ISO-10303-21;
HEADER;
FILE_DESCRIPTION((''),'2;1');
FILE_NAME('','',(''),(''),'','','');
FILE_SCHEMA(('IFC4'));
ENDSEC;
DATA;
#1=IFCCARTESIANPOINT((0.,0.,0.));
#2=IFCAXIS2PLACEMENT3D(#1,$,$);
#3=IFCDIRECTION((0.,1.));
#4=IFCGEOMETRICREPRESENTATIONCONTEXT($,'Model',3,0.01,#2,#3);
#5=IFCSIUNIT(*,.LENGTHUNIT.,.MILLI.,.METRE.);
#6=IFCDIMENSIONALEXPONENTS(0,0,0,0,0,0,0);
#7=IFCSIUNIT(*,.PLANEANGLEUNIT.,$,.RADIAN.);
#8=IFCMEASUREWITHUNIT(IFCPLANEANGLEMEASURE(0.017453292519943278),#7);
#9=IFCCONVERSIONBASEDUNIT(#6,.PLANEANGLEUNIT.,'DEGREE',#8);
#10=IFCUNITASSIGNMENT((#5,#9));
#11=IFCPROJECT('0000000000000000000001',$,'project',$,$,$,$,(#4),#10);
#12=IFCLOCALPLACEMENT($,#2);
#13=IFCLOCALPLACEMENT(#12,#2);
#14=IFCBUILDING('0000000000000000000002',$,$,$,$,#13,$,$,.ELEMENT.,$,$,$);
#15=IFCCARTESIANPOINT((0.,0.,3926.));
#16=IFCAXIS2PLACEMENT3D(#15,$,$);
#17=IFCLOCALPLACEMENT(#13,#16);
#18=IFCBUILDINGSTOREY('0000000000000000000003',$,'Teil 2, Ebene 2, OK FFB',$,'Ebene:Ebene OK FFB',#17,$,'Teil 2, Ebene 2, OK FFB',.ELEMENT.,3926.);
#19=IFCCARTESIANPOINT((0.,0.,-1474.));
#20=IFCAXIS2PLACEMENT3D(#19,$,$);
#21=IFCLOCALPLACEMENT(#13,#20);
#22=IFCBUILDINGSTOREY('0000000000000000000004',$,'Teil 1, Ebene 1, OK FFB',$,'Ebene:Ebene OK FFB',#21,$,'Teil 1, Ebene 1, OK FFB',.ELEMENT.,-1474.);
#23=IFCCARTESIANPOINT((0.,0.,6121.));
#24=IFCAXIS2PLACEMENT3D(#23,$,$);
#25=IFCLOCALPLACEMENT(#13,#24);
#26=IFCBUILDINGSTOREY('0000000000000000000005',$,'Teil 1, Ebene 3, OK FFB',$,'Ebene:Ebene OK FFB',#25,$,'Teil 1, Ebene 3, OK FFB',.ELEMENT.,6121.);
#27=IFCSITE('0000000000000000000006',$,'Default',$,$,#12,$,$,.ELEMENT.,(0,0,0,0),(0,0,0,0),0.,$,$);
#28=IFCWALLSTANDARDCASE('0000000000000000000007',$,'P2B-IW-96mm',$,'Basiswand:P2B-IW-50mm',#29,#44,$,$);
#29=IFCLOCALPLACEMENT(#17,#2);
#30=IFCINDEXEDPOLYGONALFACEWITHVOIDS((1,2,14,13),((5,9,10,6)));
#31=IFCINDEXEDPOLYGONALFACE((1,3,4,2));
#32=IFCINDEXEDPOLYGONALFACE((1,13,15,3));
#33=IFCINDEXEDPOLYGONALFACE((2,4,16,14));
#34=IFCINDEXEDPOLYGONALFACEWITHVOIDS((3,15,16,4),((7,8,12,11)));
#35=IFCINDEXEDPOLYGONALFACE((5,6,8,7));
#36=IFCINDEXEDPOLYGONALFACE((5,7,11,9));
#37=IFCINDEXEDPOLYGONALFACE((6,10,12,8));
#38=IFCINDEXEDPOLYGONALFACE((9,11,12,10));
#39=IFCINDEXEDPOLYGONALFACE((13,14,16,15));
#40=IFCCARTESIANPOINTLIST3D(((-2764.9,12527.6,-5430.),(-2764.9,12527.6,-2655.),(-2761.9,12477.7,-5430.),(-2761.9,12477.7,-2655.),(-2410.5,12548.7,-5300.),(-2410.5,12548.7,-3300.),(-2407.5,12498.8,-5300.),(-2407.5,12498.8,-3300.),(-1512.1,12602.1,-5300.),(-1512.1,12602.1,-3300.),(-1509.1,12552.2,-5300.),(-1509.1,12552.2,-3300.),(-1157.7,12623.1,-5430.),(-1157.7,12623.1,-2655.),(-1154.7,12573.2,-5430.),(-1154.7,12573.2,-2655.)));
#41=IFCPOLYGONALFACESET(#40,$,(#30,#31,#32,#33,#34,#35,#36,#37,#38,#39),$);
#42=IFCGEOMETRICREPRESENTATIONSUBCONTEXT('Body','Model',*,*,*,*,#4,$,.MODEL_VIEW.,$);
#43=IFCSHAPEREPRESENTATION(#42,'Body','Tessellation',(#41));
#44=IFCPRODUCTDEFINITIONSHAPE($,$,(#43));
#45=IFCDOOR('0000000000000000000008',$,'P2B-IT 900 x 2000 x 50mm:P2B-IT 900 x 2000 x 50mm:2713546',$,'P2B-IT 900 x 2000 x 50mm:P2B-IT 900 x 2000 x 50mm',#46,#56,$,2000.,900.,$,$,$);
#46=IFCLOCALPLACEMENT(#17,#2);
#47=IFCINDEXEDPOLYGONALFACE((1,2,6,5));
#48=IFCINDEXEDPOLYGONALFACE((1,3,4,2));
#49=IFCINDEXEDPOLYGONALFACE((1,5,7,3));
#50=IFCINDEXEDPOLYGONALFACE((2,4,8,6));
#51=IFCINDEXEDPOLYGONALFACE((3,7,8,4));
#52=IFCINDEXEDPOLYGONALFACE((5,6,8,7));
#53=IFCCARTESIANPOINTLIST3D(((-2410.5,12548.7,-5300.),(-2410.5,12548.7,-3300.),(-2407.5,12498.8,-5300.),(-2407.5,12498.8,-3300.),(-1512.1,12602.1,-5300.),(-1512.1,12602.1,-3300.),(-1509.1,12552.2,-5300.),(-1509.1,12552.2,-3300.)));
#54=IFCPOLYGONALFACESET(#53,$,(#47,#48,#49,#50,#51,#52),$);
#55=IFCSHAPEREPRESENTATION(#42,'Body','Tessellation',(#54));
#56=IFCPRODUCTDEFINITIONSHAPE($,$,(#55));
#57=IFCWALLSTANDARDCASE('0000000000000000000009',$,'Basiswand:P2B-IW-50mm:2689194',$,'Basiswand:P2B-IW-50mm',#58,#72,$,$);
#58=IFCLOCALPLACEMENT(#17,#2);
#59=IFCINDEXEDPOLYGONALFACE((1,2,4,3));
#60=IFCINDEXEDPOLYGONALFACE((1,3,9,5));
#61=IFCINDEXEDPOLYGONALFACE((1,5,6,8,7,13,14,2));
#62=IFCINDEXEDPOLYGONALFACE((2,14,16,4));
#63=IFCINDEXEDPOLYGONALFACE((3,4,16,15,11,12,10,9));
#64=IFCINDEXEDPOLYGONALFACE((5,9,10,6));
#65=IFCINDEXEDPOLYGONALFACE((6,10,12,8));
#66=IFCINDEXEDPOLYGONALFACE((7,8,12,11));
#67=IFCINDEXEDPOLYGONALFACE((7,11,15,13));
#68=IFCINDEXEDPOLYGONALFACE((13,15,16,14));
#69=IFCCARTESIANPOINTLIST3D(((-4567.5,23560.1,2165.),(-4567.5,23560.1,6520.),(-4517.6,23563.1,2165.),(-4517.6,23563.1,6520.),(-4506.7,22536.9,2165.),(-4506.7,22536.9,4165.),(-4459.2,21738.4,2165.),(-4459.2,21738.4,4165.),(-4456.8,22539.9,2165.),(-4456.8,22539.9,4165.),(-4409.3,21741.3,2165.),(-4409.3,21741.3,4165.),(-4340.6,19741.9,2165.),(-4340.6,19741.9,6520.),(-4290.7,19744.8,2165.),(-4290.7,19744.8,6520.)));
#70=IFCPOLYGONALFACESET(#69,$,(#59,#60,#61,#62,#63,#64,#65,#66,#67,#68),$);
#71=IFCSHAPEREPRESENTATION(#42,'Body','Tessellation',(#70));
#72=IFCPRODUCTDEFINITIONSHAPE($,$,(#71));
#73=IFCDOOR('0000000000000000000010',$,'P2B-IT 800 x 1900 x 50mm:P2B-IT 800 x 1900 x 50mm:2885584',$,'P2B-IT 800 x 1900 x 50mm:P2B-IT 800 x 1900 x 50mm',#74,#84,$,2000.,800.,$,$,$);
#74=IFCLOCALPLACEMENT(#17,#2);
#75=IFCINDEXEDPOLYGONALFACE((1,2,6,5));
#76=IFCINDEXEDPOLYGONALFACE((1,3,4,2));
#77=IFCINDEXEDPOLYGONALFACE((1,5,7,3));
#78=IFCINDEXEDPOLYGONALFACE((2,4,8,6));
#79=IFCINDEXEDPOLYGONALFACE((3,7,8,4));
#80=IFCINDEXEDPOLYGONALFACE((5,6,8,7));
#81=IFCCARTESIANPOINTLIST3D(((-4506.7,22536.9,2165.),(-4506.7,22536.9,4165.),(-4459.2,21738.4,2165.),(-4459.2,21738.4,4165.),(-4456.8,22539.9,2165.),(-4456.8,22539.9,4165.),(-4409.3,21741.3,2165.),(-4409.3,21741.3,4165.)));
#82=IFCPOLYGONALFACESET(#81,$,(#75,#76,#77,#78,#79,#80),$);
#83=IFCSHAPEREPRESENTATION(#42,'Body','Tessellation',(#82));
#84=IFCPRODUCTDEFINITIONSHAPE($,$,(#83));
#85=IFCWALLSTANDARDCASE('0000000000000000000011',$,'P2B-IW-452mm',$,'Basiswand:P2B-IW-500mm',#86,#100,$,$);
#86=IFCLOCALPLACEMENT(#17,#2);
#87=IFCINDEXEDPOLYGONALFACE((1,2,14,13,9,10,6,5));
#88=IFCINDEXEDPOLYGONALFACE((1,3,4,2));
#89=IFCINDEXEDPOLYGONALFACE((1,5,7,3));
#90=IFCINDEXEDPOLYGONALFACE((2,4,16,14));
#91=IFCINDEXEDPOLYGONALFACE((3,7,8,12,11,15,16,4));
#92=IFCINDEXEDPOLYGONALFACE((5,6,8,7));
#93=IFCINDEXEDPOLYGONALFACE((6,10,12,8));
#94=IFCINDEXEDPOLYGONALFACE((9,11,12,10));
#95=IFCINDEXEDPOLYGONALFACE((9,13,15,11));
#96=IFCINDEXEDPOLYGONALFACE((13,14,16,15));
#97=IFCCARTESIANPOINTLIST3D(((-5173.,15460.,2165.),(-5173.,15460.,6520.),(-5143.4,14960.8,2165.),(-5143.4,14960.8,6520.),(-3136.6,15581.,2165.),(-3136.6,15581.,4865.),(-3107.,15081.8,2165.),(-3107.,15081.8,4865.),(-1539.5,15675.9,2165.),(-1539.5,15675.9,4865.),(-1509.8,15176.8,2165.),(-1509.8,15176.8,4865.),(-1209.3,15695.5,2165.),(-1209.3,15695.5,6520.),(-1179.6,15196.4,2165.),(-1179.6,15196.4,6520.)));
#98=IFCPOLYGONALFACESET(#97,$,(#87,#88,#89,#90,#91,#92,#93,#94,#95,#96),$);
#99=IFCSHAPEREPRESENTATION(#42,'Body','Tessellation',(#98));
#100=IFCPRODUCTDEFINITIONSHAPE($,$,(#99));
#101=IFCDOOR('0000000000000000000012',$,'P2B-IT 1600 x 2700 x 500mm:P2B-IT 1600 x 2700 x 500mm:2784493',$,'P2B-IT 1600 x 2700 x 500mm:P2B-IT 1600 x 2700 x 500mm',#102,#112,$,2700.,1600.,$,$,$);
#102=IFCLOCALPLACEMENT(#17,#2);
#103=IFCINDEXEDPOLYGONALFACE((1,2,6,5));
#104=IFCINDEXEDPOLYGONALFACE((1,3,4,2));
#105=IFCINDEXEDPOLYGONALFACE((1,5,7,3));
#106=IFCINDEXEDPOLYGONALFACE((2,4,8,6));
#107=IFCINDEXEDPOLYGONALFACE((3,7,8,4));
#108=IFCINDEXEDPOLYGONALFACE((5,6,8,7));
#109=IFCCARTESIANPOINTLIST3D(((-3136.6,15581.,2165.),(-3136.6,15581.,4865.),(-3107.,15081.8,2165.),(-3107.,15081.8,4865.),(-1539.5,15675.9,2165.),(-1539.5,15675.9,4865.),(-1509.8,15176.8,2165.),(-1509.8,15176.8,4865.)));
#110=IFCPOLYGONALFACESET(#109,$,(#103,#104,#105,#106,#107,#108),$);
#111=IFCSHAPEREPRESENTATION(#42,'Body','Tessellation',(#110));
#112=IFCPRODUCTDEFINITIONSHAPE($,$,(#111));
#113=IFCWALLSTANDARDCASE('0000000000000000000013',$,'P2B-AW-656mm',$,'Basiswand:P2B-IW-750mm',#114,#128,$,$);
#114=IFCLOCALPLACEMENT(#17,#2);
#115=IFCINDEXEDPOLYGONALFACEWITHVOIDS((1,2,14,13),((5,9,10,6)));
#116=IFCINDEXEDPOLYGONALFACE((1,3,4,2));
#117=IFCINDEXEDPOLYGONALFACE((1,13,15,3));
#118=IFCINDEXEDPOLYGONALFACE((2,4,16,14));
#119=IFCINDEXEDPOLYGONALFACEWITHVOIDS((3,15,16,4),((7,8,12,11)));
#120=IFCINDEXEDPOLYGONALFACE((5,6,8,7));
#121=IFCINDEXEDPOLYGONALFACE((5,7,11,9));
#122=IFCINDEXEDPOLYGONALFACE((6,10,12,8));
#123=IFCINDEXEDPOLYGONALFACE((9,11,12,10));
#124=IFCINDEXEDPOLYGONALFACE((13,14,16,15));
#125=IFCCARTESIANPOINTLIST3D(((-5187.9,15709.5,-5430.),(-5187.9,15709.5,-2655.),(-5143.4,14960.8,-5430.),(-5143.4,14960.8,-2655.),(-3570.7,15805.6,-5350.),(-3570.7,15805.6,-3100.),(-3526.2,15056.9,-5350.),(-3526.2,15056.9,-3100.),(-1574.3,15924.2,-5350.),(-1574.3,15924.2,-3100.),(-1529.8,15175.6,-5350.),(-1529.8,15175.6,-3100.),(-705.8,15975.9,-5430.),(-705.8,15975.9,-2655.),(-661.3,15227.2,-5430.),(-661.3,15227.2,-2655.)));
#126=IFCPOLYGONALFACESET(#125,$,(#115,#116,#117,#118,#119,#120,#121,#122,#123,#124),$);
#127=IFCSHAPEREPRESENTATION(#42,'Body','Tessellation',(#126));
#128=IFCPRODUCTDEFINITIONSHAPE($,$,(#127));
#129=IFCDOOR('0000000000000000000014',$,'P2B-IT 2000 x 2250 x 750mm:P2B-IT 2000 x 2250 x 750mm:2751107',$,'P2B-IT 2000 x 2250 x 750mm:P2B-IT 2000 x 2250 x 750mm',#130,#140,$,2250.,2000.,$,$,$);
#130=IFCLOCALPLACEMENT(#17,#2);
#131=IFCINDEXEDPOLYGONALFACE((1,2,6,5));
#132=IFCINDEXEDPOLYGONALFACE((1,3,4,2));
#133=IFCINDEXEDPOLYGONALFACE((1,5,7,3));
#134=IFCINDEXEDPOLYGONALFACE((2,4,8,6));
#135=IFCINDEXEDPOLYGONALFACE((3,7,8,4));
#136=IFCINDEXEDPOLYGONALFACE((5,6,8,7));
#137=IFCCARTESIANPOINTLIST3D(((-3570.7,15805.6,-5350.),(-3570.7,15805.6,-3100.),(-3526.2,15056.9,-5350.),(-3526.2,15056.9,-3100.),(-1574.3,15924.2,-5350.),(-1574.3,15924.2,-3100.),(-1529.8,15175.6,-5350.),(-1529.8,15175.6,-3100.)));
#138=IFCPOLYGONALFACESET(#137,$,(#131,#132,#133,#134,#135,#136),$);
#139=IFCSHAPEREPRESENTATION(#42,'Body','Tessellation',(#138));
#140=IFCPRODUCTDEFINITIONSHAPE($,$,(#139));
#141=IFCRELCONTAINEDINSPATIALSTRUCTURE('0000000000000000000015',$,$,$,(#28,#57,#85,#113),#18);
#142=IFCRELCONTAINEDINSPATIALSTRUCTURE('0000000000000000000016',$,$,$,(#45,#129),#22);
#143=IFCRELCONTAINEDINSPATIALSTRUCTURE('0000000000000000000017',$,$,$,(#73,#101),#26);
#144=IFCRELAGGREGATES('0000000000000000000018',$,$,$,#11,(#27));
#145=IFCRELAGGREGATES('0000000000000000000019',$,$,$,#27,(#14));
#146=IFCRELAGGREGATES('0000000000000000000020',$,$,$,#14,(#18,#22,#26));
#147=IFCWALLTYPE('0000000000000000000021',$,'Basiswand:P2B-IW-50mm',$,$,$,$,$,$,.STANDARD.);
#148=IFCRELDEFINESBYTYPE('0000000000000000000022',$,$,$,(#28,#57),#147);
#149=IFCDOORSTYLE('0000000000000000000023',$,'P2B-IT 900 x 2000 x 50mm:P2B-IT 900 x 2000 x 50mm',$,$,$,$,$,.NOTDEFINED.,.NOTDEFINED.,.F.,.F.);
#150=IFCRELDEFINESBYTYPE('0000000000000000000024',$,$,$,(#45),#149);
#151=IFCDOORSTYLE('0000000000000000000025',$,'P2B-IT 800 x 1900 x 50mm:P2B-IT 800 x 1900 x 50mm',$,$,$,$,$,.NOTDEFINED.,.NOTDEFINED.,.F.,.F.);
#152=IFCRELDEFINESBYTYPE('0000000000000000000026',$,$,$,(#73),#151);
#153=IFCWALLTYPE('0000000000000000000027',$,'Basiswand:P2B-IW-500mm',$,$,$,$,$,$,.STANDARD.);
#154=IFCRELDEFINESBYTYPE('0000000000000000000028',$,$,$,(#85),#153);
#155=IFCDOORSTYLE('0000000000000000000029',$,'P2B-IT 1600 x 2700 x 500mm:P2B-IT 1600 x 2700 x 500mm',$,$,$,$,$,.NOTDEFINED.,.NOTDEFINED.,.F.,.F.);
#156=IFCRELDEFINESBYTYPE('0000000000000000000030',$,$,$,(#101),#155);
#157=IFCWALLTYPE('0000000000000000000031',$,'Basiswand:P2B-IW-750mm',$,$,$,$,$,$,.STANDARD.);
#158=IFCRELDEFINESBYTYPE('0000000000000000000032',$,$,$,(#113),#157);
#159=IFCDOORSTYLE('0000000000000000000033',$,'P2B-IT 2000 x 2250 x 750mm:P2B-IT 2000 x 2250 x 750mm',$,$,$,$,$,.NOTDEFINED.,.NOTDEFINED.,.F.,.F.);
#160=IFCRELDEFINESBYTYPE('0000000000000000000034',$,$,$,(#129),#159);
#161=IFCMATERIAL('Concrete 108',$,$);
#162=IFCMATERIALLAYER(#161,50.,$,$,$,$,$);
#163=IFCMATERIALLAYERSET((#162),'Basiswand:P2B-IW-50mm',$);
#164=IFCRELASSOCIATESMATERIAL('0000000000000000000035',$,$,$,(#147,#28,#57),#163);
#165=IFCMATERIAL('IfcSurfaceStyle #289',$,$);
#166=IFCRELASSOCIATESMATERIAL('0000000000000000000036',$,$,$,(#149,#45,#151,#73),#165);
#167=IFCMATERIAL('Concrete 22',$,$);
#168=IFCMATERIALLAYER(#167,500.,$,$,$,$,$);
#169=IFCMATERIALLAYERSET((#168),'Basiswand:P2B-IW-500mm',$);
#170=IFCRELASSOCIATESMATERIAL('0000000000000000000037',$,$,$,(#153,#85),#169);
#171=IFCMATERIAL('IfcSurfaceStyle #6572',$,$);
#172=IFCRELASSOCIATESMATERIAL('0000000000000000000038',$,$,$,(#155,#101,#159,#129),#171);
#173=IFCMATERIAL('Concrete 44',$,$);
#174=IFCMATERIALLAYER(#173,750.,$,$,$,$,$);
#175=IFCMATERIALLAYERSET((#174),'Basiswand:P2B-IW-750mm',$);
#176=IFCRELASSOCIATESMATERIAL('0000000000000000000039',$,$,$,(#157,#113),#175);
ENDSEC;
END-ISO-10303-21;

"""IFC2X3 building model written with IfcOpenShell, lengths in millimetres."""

from ifc_helpers import new_model, entity, si_unit, converted_unit, direction, frame, frame_2d, origin, origin_2d_with_axis, place, context, subcontext, project, spatial, rectangle, extrude, source, transform, mapped, material, layer, layer_set, layer_usage, type_object, type_shapes, element, fill, save


model = new_model("IFC2X3")

# Units and contexts
model_context = context("Model", 3, precision=0.01, world=origin(), true_north=direction((0.0, 1.0)))
body_context = subcontext(model_context, "Body", "Model", "MODEL_VIEW")
ifc_project = project(units=[si_unit("LENGTHUNIT", "METRE", prefix="MILLI"), converted_unit("PLANEANGLEUNIT", "DEGREE", entity("IfcPlaneAngleMeasure", 0.017453292519943278), si_unit("PLANEANGLEUNIT", "RADIAN"), dimensions=[0, 0, 0, 0, 0, 0, 0])], contexts=[model_context])

# Site, building, storey
site_placement = place(None, origin())
site = spatial("IfcSite", under=ifc_project, at=site_placement, Name="Default", CompositionType="ELEMENT", RefLatitude=(0, 0, 0, 0), RefLongitude=(0, 0, 0, 0), RefElevation=0.0)
building_placement = place(site_placement, origin())
building = spatial("IfcBuilding", under=site, at=building_placement, CompositionType="ELEMENT")
storey_1_placement = place(building_placement, frame((0.0, 0.0, 3926.0)))
storey_1 = spatial("IfcBuildingStorey", under=building, at=storey_1_placement, Name="Teil 2, Ebene 2, OK FFB", ObjectType="Ebene:Ebene OK FFB", LongName="Teil 2, Ebene 2, OK FFB", CompositionType="ELEMENT", Elevation=3926.0)

# Shared definitions
storey_2_placement = place(building_placement, frame((0.0, 0.0, -1474.0)))
storey_2 = spatial("IfcBuildingStorey", under=building, at=storey_2_placement, Name="Teil 1, Ebene 1, OK FFB", ObjectType="Ebene:Ebene OK FFB", LongName="Teil 1, Ebene 1, OK FFB", CompositionType="ELEMENT", Elevation=-1474.0)

# Shared definitions
ifc_material_1 = material(Name="IfcSurfaceStyle #289")

# Shared definitions
ifc_material_2 = material(Name="Concrete 44")

# Shared definitions
storey_3_placement = place(building_placement, frame((0.0, 0.0, 6121.0)))
storey_3 = spatial("IfcBuildingStorey", under=building, at=storey_3_placement, Name="Teil 1, Ebene 3, OK FFB", ObjectType="Ebene:Ebene OK FFB", LongName="Teil 1, Ebene 3, OK FFB", CompositionType="ELEMENT", Elevation=6121.0)

# Walls, openings, doors
ifc_material_3 = material(Name="Concrete 108")
ifc_layer_1 = layer(ifc_material_3, 50.0)
ifc_layer_set_1 = layer_set([ifc_layer_1], Name="Basiswand:P2B-IW-50mm")
ifc_layer_usage_1 = layer_usage(ifc_layer_set_1, "AXIS2", "NEGATIVE", 25.0)
wall_type_1 = type_object("IfcWallType", Name="Basiswand:P2B-IW-50mm", PredefinedType="STANDARD", material=ifc_layer_set_1)
wall_1_placement = place(storey_1_placement, frame((-1156.2, 12598.2, -5430.0), z_axis=(0.0, 0.0, 1.0), x_axis=(-0.998239, -0.059319, 0.0)))
wall_1 = element("IfcWallStandardCase", 1, at=wall_1_placement, inside=storey_1, type_object=wall_type_1, material=ifc_layer_usage_1, Name="P2B-IW-96mm", ObjectType="Basiswand:P2B-IW-50mm", context=body_context, shape_type="SweptSolid", body=[
    extrude(rectangle(XDim=1610.0, YDim=50.0, at=frame_2d((805.0, 0.0), x_axis=(-1.0, 0.0))), origin(), (0.0, 0.0, 1.0), 2775.0),
])
opening_1_placement = place(wall_1_placement, frame((-406.9, 12644.6, 30.0), z_axis=(0.0, 0.0, 1.0), x_axis=(-0.998239, 0.059319, 0.0)))
opening_1 = element("IfcOpeningElement", 2, at=opening_1_placement, cuts=wall_1, ObjectType="Opening", context=body_context, shape_type="SweptSolid", body=[
    extrude(rectangle(XDim=2000.0, YDim=900.0, at=frame_2d((0.0, 0.0), x_axis=(1.0, 0.0))), frame((-1961.3, 12575.4, 1100.0), z_axis=(0.059319, -0.998239, 0.0), x_axis=(0.0, 0.0, -1.0)), (0.0, 0.0, 1.0), 50.0),
])
door_style_1 = type_object("IfcDoorStyle", Name="P2B-IT 900 x 2000 x 50mm:P2B-IT 900 x 2000 x 50mm", ConstructionType="NOTDEFINED", OperationType="NOTDEFINED", ParameterTakesPrecedence=False, Sizeable=False, material=ifc_material_1)
shared_shape_1 = source(origin(), body_context, "Body", "SweptSolid", [
    extrude(rectangle(XDim=50.0, YDim=900.0, at=origin_2d_with_axis()), frame((450.0, 25.0, 0.0), z_axis=(0.0, 0.0, 1.0), x_axis=(0.0, 1.0, 0.0)), (0.0, 0.0, 1.0), 2000.0),
])
type_shapes(door_style_1, [shared_shape_1])
door_1_placement = place(opening_1_placement, frame((-2407.5, 12498.8, 100.0), z_axis=(0.0, 0.0, 1.0), x_axis=(0.998239, 0.059319, 0.0)))
door_1 = element("IfcDoor", 3, at=door_1_placement, inside=storey_2, type_object=door_style_1, material=ifc_material_1, Name="P2B-IT 900 x 2000 x 50mm:P2B-IT 900 x 2000 x 50mm:2713546", ObjectType="P2B-IT 900 x 2000 x 50mm:P2B-IT 900 x 2000 x 50mm", OverallHeight=2000.0, OverallWidth=900.0, context=body_context, shape_type="MappedRepresentation", body=[
    mapped(shared_shape_1, transform((0.0, 0.0, 0.0), scale=1.0)),
])
fill(opening_1, door_1)
ifc_layer_usage_2 = layer_usage(ifc_layer_set_1, "AXIS2", "NEGATIVE", 25.0)
wall_2_placement = place(storey_1_placement, frame((-4315.6, 19743.4, 2165.0), z_axis=(0.0, 0.0, 1.0), x_axis=(-0.059319, 0.998239, 0.0)))
wall_2 = element("IfcWallStandardCase", 4, at=wall_2_placement, inside=storey_1, type_object=wall_type_1, material=ifc_layer_usage_2, Name="Basiswand:P2B-IW-50mm:2689194", ObjectType="Basiswand:P2B-IW-50mm", context=body_context, shape_type="SweptSolid", body=[
    extrude(rectangle(XDim=3825.0, YDim=50.0, at=frame_2d((1912.5, 0.0), x_axis=(1.0, 0.0))), origin(), (0.0, 0.0, 1.0), 4355.0),
])
opening_2_placement = place(wall_2_placement, frame((-19964.6, -3136.9, 30.0), z_axis=(0.0, 0.0, 1.0), x_axis=(-0.059319, -0.998239, 0.0)))
opening_2 = element("IfcOpeningElement", 5, at=opening_2_placement, cuts=wall_2, ObjectType="Opening", context=body_context, shape_type="SweptSolid", body=[
    extrude(rectangle(XDim=2000.0, YDim=800.0, at=frame_2d((0.0, 0.0), x_axis=(1.0, 0.0))), frame((-4433.0, 22140.6, 970.0), z_axis=(-0.998239, -0.059319, 0.0), x_axis=(0.0, 0.0, -1.0)), (0.0, 0.0, 1.0), 50.0),
])
door_style_2 = type_object("IfcDoorStyle", Name="P2B-IT 800 x 1900 x 50mm:P2B-IT 800 x 1900 x 50mm", ConstructionType="NOTDEFINED", OperationType="NOTDEFINED", ParameterTakesPrecedence=False, Sizeable=False, material=ifc_material_1)
shared_shape_2 = source(origin(), body_context, "Body", "SweptSolid", [
    extrude(rectangle(XDim=50.0, YDim=800.0, at=origin_2d_with_axis()), frame((400.0, -25.0, 0.0), z_axis=(0.0, 0.0, 1.0), x_axis=(0.0, 1.0, 0.0)), (0.0, 0.0, 1.0), 2000.0),
])
type_shapes(door_style_2, [shared_shape_2])
door_2_placement = place(opening_2_placement, frame((-4459.2, 21738.4, -30.0), z_axis=(0.0, 0.0, 1.0), x_axis=(-0.059319, 0.998239, 0.0)))
door_2 = element("IfcDoor", 6, at=door_2_placement, inside=storey_3, type_object=door_style_2, material=ifc_material_1, Name="P2B-IT 800 x 1900 x 50mm:P2B-IT 800 x 1900 x 50mm:2885584", ObjectType="P2B-IT 800 x 1900 x 50mm:P2B-IT 800 x 1900 x 50mm", OverallHeight=2000.0, OverallWidth=800.0, context=body_context, shape_type="MappedRepresentation", body=[
    mapped(shared_shape_2, transform((0.0, 0.0, 0.0), scale=1.0)),
])
fill(opening_2, door_2)
ifc_material_4 = material(Name="Concrete 22")
ifc_layer_2 = layer(ifc_material_4, 500.0)
ifc_layer_set_2 = layer_set([ifc_layer_2], Name="Basiswand:P2B-IW-500mm")
ifc_layer_usage_3 = layer_usage(ifc_layer_set_2, "AXIS2", "NEGATIVE", 250.0)
wall_type_2 = type_object("IfcWallType", Name="Basiswand:P2B-IW-500mm", PredefinedType="STANDARD", material=ifc_layer_set_2)
wall_3_placement = place(storey_1_placement, frame((-1194.5, 15445.9, 2165.0), z_axis=(0.0, 0.0, 1.0), x_axis=(-0.998239, -0.059319, 0.0)))
wall_3 = element("IfcWallStandardCase", 7, at=wall_3_placement, inside=storey_1, type_object=wall_type_2, material=ifc_layer_usage_3, Name="P2B-IW-452mm", ObjectType="Basiswand:P2B-IW-500mm", context=body_context, shape_type="SweptSolid", body=[
    extrude(rectangle(XDim=3970.7, YDim=500.0, at=frame_2d((1985.4, 0.0), x_axis=(1.0, 0.0))), origin(), (0.0, 0.0, 1.0), 4355.0),
])
opening_3_placement = place(wall_3_placement, frame((-276.1, 15489.6, 30.0), z_axis=(0.0, 0.0, 1.0), x_axis=(-0.998239, 0.059319, 0.0)))
opening_3 = element("IfcOpeningElement", 8, at=opening_3_placement, cuts=wall_3, ObjectType="Opening", context=body_context, shape_type="SweptSolid", body=[
    extrude(rectangle(XDim=2700.0, YDim=1600.0, at=frame_2d((0.0, 0.0), x_axis=(1.0, 0.0))), frame((-2338.0, 15628.4, 1320.0), z_axis=(0.059319, -0.998239, 0.0), x_axis=(0.0, 0.0, -1.0)), (0.0, 0.0, 1.0), 500.0),
])
ifc_material_5 = material(Name="IfcSurfaceStyle #6572")
door_style_3 = type_object("IfcDoorStyle", Name="P2B-IT 1600 x 2700 x 500mm:P2B-IT 1600 x 2700 x 500mm", ConstructionType="NOTDEFINED", OperationType="NOTDEFINED", ParameterTakesPrecedence=False, Sizeable=False, material=ifc_material_5)
shared_shape_3 = source(origin(), body_context, "Body", "SweptSolid", [
    extrude(rectangle(XDim=500.0, YDim=1600.0, at=origin_2d_with_axis()), frame((800.0, 250.0, 0.0), z_axis=(0.0, 0.0, 1.0), x_axis=(0.0, 1.0, 0.0)), (0.0, 0.0, 1.0), 2700.0),
])
type_shapes(door_style_3, [shared_shape_3])
door_3_placement = place(opening_3_placement, frame((-3107.0, 15081.8, -30.0), z_axis=(0.0, 0.0, 1.0), x_axis=(0.998239, 0.059319, 0.0)))
door_3 = element("IfcDoor", 9, at=door_3_placement, inside=storey_3, type_object=door_style_3, material=ifc_material_5, Name="P2B-IT 1600 x 2700 x 500mm:P2B-IT 1600 x 2700 x 500mm:2784493", ObjectType="P2B-IT 1600 x 2700 x 500mm:P2B-IT 1600 x 2700 x 500mm", OverallHeight=2700.0, OverallWidth=1600.0, context=body_context, shape_type="MappedRepresentation", body=[
    mapped(shared_shape_3, transform((0.0, 0.0, 0.0), scale=1.0)),
])
fill(opening_3, door_3)
ifc_layer_3 = layer(ifc_material_2, 750.0)
ifc_layer_set_3 = layer_set([ifc_layer_3], Name="Basiswand:P2B-IW-750mm")
ifc_layer_usage_4 = layer_usage(ifc_layer_set_3, "AXIS2", "NEGATIVE", 375.0)
wall_type_3 = type_object("IfcWallType", Name="Basiswand:P2B-IW-750mm", PredefinedType="STANDARD", material=ifc_layer_set_3)
wall_4_placement = place(storey_1_placement, frame((-683.5, 15601.5, -5430.0), z_axis=(0.0, 0.0, 1.0), x_axis=(-0.998239, -0.059319, 0.0)))
wall_4 = element("IfcWallStandardCase", 10, at=wall_4_placement, inside=storey_1, type_object=wall_type_3, material=ifc_layer_usage_4, Name="P2B-AW-656mm", ObjectType="Basiswand:P2B-IW-750mm", context=body_context, shape_type="SweptSolid", body=[
    extrude(rectangle(XDim=4490.0, YDim=750.0, at=frame_2d((2245.0, 0.0), x_axis=(-1.0, 0.0))), origin(), (0.0, 0.0, 1.0), 2775.0),
])
opening_4_placement = place(wall_4_placement, frame((243.1, 15614.6, 30.0), z_axis=(0.0, 0.0, 1.0), x_axis=(-0.998239, 0.059319, 0.0)))
opening_4 = element("IfcOpeningElement", 11, at=opening_4_placement, cuts=wall_4, ObjectType="Opening", context=body_context, shape_type="SweptSolid", body=[
    extrude(rectangle(XDim=2250.0, YDim=2000.0, at=frame_2d((0.0, 0.0), x_axis=(1.0, 0.0))), frame((-2572.5, 15864.9, 1175.0), z_axis=(0.059319, -0.998239, 0.0), x_axis=(0.0, 0.0, -1.0)), (0.0, 0.0, 1.0), 750.0),
])
door_style_4 = type_object("IfcDoorStyle", Name="P2B-IT 2000 x 2250 x 750mm:P2B-IT 2000 x 2250 x 750mm", ConstructionType="NOTDEFINED", OperationType="NOTDEFINED", ParameterTakesPrecedence=False, Sizeable=False, material=ifc_material_5)
shared_shape_4 = source(origin(), body_context, "Body", "SweptSolid", [
    extrude(rectangle(XDim=750.0, YDim=2000.0, at=origin_2d_with_axis()), frame((1000.0, -375.0, 0.0), z_axis=(0.0, 0.0, 1.0), x_axis=(0.0, 1.0, 0.0)), (0.0, 0.0, 1.0), 2250.0),
])
type_shapes(door_style_4, [shared_shape_4])
door_4_placement = place(opening_4_placement, frame((-1529.8, 15175.6, 50.0), z_axis=(0.0, 0.0, 1.0), x_axis=(-0.998239, -0.059319, 0.0)))
door_4 = element("IfcDoor", 12, at=door_4_placement, inside=storey_2, type_object=door_style_4, material=ifc_material_5, Name="P2B-IT 2000 x 2250 x 750mm:P2B-IT 2000 x 2250 x 750mm:2751107", ObjectType="P2B-IT 2000 x 2250 x 750mm:P2B-IT 2000 x 2250 x 750mm", OverallHeight=2250.0, OverallWidth=2000.0, context=body_context, shape_type="MappedRepresentation", body=[
    mapped(shared_shape_4, transform((0.0, 0.0, 0.0), scale=1.0)),
])
fill(opening_4, door_4)

save(model, "model.ifc")
